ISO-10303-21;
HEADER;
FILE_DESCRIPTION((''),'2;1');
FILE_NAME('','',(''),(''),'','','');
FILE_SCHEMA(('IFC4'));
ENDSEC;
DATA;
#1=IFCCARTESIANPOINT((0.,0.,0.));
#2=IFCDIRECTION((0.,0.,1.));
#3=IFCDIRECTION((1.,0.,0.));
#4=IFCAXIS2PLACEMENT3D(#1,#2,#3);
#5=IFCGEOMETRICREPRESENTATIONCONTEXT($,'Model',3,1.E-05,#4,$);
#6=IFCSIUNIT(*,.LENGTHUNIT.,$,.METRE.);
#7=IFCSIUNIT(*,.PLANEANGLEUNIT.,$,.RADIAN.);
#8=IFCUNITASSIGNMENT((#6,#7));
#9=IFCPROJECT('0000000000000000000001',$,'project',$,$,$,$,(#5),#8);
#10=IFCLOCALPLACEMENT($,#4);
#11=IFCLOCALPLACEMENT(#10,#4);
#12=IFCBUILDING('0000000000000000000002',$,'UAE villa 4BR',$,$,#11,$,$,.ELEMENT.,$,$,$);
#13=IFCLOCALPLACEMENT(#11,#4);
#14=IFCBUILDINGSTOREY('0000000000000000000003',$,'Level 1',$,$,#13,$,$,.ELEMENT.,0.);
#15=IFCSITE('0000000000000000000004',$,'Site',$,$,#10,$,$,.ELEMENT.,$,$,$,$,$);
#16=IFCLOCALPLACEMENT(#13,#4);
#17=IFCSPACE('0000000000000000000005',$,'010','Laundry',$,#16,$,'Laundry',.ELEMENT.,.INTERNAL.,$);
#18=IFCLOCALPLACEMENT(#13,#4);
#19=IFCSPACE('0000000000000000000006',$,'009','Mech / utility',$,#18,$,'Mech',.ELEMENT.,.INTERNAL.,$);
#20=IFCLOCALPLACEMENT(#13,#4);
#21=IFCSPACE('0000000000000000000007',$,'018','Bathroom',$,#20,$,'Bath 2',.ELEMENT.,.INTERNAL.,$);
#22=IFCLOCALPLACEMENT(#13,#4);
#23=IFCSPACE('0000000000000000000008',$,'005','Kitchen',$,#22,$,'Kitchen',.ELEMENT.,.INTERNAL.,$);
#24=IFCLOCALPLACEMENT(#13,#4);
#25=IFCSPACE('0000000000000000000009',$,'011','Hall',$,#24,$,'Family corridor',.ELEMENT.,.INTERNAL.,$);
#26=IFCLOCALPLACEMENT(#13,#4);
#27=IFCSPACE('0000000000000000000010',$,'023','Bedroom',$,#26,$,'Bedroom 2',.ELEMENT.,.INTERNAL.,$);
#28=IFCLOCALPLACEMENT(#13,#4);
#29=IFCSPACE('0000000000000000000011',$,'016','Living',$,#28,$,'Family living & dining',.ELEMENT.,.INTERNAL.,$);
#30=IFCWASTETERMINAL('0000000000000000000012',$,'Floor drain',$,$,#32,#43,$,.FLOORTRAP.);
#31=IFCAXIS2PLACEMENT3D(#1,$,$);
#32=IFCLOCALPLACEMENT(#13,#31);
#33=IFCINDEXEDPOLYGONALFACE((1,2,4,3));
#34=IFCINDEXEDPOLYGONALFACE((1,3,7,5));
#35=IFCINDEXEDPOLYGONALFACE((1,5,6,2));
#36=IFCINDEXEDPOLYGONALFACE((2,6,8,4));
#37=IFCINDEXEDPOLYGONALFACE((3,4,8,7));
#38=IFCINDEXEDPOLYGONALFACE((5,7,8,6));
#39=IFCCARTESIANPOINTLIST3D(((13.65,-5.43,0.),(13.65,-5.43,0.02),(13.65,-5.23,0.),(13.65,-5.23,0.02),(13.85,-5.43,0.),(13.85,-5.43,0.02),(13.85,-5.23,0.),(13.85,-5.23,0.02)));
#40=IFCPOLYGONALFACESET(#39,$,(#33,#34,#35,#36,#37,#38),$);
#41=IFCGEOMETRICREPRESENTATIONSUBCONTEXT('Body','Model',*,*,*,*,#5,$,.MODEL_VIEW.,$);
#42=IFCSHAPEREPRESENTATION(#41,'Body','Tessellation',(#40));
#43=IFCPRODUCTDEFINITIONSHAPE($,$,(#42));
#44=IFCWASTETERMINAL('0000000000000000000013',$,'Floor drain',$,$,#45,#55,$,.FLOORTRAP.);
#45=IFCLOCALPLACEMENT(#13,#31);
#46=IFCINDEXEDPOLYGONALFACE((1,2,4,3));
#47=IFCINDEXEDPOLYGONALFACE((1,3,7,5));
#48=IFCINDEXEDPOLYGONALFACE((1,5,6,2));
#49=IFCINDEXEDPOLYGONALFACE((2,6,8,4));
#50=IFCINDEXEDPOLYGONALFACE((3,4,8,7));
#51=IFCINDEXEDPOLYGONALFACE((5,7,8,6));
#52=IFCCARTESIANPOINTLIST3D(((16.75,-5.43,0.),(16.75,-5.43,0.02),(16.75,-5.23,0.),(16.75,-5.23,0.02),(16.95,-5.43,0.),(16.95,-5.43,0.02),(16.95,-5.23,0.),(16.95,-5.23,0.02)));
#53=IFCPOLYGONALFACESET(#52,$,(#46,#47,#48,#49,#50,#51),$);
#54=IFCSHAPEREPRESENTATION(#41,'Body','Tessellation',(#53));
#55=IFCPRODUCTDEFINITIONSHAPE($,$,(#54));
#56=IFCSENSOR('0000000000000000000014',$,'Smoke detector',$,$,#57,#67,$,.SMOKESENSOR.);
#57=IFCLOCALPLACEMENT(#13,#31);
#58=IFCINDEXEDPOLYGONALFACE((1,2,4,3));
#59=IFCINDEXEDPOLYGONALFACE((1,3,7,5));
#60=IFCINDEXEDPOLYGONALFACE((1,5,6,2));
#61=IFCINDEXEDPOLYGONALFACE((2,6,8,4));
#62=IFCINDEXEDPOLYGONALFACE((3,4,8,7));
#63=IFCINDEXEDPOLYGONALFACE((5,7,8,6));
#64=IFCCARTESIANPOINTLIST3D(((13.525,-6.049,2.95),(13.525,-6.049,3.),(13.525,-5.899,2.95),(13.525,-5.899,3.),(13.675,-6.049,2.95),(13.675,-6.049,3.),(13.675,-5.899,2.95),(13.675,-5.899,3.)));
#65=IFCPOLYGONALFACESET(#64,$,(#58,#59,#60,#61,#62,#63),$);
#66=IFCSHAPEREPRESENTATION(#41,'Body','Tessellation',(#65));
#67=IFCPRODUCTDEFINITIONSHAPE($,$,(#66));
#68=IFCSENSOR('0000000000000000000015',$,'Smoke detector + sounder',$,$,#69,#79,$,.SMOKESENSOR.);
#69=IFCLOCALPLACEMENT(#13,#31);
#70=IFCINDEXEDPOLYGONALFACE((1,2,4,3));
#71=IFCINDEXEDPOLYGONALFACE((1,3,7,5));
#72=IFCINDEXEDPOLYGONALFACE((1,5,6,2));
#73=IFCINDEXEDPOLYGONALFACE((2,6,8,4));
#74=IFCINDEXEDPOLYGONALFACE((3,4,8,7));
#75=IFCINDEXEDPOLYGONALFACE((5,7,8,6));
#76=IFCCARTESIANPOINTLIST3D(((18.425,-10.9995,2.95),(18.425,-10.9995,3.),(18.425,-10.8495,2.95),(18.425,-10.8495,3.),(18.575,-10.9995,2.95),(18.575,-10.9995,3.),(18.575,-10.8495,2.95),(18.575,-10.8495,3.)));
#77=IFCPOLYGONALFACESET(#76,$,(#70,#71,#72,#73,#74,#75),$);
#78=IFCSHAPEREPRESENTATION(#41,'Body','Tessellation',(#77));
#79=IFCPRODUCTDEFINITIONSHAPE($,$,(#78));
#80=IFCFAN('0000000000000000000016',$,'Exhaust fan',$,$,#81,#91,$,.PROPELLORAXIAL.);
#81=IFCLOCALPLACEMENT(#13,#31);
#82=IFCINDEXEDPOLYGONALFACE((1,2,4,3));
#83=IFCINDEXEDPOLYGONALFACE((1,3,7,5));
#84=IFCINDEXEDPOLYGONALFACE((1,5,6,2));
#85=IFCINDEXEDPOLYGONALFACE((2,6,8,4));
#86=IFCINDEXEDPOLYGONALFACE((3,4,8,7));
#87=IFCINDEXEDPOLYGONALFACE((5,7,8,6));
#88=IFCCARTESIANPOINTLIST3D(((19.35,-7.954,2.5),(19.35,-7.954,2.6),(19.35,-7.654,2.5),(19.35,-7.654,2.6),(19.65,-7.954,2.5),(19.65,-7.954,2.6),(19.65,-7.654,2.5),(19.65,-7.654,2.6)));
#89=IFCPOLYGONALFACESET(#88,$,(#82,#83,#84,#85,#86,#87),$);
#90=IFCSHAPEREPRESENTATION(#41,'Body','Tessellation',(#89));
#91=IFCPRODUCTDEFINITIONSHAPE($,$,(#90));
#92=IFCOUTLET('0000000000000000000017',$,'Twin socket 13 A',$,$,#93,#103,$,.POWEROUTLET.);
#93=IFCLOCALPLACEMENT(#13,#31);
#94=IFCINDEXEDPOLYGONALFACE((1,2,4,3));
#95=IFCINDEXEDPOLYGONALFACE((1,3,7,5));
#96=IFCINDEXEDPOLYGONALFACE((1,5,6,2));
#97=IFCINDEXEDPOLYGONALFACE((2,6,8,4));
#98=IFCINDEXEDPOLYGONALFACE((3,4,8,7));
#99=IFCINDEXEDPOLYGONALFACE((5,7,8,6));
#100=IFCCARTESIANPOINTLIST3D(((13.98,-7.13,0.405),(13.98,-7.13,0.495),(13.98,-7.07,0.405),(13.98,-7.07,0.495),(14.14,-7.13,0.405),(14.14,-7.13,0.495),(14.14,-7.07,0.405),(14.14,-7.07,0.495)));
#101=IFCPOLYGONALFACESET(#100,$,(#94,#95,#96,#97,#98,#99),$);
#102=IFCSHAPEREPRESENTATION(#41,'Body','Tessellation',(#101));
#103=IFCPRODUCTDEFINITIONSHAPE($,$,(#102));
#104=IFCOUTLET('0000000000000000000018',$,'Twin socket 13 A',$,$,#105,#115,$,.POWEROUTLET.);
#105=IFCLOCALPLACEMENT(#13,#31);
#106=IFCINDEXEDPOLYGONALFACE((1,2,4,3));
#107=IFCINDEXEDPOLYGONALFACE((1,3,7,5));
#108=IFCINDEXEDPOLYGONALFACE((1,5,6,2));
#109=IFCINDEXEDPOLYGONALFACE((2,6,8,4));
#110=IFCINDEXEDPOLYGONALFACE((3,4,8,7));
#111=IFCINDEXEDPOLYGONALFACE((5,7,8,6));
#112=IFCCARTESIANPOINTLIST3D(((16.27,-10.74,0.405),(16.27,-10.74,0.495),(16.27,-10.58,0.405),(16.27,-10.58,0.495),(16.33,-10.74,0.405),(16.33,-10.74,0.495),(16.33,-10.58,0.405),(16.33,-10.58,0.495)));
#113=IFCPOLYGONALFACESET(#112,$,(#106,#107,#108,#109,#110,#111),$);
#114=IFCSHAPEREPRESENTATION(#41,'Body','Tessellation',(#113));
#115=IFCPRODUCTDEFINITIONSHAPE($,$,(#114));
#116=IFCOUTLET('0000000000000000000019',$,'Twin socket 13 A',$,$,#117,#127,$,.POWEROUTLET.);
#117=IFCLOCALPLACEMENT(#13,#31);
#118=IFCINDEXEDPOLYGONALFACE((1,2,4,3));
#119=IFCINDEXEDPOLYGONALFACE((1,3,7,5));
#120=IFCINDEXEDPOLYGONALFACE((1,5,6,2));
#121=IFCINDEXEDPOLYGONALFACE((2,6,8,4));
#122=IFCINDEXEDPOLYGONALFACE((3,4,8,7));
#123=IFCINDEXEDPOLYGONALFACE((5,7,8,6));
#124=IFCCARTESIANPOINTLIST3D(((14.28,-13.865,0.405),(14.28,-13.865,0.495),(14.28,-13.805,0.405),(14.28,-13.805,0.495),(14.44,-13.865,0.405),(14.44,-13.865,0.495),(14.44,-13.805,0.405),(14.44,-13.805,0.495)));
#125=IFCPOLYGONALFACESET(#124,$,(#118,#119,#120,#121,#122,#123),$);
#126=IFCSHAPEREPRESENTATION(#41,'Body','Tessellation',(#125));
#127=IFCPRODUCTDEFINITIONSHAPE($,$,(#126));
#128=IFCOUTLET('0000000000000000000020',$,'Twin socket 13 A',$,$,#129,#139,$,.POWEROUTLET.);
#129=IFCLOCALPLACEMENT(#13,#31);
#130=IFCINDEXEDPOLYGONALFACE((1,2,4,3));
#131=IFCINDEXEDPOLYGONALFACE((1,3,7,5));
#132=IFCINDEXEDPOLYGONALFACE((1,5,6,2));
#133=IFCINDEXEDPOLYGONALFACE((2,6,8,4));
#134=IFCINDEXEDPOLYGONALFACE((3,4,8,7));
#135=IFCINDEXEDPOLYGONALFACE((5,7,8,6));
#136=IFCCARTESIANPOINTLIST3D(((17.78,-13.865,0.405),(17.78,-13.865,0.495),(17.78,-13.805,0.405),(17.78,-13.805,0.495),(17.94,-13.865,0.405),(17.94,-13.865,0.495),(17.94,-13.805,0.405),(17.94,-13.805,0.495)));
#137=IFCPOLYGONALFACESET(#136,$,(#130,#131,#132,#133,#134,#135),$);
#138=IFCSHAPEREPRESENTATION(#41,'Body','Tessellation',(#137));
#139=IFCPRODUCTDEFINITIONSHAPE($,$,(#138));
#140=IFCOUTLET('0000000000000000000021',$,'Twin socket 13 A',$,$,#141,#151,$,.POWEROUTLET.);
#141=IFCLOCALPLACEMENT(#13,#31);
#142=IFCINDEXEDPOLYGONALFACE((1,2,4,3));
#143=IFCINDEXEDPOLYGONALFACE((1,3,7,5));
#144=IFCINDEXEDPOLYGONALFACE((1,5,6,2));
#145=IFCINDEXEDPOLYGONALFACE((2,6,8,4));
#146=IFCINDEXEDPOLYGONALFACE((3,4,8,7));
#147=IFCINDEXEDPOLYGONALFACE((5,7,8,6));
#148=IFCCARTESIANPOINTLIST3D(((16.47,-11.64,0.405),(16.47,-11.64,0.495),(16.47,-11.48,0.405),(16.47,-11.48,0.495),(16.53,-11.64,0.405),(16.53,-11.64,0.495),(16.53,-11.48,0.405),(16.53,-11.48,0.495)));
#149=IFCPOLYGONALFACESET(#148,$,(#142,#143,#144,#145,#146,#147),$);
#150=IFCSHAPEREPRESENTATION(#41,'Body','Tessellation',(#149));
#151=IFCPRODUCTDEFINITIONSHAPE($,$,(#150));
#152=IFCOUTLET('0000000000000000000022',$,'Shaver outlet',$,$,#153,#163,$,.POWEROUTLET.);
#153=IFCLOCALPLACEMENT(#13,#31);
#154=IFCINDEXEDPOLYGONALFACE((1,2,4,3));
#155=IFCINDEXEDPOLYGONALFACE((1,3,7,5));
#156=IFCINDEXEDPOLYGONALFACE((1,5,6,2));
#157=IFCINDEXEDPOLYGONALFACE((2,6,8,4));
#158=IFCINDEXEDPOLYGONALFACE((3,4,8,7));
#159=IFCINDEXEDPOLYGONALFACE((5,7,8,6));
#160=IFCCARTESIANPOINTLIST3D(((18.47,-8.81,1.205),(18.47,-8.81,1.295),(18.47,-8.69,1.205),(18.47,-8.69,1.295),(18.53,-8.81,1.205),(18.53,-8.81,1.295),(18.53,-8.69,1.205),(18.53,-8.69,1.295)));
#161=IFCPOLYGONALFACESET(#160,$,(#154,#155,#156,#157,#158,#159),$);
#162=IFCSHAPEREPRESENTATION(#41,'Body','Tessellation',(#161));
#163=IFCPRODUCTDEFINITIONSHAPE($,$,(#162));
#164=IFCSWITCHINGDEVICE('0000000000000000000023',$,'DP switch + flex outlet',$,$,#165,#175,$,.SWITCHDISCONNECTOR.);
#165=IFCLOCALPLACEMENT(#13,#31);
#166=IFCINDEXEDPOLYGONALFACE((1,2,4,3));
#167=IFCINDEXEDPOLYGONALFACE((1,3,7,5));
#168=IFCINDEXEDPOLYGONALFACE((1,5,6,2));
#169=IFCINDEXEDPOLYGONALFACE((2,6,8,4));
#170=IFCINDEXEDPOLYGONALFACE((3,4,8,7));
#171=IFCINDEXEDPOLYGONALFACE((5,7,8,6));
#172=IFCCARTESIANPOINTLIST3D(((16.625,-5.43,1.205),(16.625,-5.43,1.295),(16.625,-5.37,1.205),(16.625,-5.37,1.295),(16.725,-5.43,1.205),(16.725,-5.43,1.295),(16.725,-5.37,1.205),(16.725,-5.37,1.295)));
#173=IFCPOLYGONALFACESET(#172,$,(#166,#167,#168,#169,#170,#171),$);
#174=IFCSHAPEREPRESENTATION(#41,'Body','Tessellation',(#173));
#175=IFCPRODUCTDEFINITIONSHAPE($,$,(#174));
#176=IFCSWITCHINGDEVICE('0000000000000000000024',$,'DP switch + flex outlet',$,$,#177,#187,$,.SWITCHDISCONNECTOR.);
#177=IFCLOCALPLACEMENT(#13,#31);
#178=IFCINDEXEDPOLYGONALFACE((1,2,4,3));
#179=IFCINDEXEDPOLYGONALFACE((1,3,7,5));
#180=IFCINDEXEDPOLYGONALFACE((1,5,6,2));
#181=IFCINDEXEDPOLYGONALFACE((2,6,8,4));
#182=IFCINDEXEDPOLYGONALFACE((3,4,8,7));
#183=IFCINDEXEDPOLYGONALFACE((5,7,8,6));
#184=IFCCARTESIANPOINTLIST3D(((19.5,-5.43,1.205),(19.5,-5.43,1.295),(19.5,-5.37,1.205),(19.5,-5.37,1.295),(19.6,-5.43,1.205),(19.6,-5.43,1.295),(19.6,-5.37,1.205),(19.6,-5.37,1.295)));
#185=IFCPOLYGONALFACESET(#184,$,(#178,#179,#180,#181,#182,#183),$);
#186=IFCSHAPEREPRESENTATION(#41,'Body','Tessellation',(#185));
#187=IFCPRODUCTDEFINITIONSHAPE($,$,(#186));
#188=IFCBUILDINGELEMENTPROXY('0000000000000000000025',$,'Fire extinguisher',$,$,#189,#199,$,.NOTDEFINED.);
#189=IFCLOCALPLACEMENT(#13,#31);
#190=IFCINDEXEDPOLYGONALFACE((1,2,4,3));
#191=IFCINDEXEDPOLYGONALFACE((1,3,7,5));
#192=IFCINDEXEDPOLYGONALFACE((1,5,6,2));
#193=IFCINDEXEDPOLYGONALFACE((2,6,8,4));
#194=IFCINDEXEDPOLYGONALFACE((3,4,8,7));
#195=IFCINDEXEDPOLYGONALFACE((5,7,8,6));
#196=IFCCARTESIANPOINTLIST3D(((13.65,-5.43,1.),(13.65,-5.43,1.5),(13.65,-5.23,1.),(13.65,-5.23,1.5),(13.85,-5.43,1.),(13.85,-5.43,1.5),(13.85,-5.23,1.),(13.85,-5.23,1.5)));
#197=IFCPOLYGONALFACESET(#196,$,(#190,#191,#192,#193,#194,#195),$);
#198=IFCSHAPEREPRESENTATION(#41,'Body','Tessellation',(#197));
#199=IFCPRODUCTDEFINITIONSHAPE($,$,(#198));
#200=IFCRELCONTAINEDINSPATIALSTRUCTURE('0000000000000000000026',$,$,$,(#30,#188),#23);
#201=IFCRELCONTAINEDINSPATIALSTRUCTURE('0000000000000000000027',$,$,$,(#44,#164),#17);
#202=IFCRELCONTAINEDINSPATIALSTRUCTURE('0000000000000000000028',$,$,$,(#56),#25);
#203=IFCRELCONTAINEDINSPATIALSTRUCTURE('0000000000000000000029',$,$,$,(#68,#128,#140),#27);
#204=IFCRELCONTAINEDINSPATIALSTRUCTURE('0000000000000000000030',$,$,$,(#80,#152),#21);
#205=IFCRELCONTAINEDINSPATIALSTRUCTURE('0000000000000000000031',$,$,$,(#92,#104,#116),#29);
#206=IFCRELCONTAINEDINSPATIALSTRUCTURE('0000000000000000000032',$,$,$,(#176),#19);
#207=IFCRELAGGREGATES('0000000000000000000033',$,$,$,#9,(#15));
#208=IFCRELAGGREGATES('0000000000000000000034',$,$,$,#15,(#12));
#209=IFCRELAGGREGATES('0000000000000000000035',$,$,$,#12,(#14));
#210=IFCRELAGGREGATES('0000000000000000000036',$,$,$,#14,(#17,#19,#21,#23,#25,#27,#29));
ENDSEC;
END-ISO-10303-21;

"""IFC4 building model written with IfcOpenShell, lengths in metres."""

from ifc_helpers import new_model, si_unit, frame, origin, origin_with_axes, origin_2d, place, context, subcontext, project, spatial, rectangle, extrude, element, save


model = new_model("IFC4")

# Units and contexts
model_context = context("Model", 3, precision=1e-05, world=origin_with_axes())
body_context = subcontext(model_context, "Body", "Model", "MODEL_VIEW")
ifc_project = project(units=[si_unit("LENGTHUNIT", "METRE"), si_unit("PLANEANGLEUNIT", "RADIAN")], contexts=[model_context])

# Site, building, storey
site_placement = place(None, origin_with_axes())
site = spatial("IfcSite", under=ifc_project, at=site_placement, Name="Site", CompositionType="ELEMENT")
building_placement = place(site_placement, origin_with_axes())
building = spatial("IfcBuilding", under=site, at=building_placement, Name="UAE villa 4BR", CompositionType="ELEMENT")
storey_placement = place(building_placement, origin_with_axes())
storey = spatial("IfcBuildingStorey", under=building, at=storey_placement, Name="Level 1", CompositionType="ELEMENT", Elevation=0.0)

# Shared definitions
space_1_placement = place(storey_placement, origin_with_axes())
space_1 = spatial("IfcSpace", under=storey, at=space_1_placement, Name="010", Description="Laundry", LongName="Laundry", CompositionType="ELEMENT", PredefinedType="INTERNAL")

# Shared definitions
space_2_placement = place(storey_placement, origin_with_axes())
space_2 = spatial("IfcSpace", under=storey, at=space_2_placement, Name="009", Description="Mech / utility", LongName="Mech", CompositionType="ELEMENT", PredefinedType="INTERNAL")

# Shared definitions
space_3_placement = place(storey_placement, origin_with_axes())
space_3 = spatial("IfcSpace", under=storey, at=space_3_placement, Name="018", Description="Bathroom", LongName="Bath 2", CompositionType="ELEMENT", PredefinedType="INTERNAL")

# Shared definitions
space_4_placement = place(storey_placement, origin_with_axes())
space_4 = spatial("IfcSpace", under=storey, at=space_4_placement, Name="005", Description="Kitchen", LongName="Kitchen", CompositionType="ELEMENT", PredefinedType="INTERNAL")

# Waste terminals
waste_terminal_1_placement = place(storey_placement, frame((13.75, -5.33, 0.0), z_axis=(0.0, 0.0, 1.0), x_axis=(-1.0, 0.0, 0.0)))
element("IfcWasteTerminal", 1, at=waste_terminal_1_placement, inside=space_4, Name="Floor drain", PredefinedType="FLOORTRAP", context=body_context, shape_type="SweptSolid", body=[
    extrude(rectangle(XDim=0.2, YDim=0.2, at=origin_2d()), origin(), (0.0, 0.0, 1.0), 0.02),
])
waste_terminal_2_placement = place(storey_placement, frame((16.85, -5.33, 0.0), z_axis=(0.0, 0.0, 1.0), x_axis=(-1.0, 0.0, 0.0)))
element("IfcWasteTerminal", 2, at=waste_terminal_2_placement, inside=space_1, Name="Floor drain", PredefinedType="FLOORTRAP", context=body_context, shape_type="SweptSolid", body=[
    extrude(rectangle(XDim=0.2, YDim=0.2, at=origin_2d()), origin(), (0.0, 0.0, 1.0), 0.02),
])

# Shared definitions
space_5_placement = place(storey_placement, origin_with_axes())
space_5 = spatial("IfcSpace", under=storey, at=space_5_placement, Name="011", Description="Hall", LongName="Family corridor", CompositionType="ELEMENT", PredefinedType="INTERNAL")

# Sensor
sensor_1_placement = place(storey_placement, frame((13.6, -5.974, 2.95), z_axis=(0.0, 0.0, 1.0), x_axis=(1.0, 0.0, 0.0)))
element("IfcSensor", 3, at=sensor_1_placement, inside=space_5, Name="Smoke detector", PredefinedType="SMOKESENSOR", context=body_context, shape_type="SweptSolid", body=[
    extrude(rectangle(XDim=0.15, YDim=0.15, at=origin_2d()), origin(), (0.0, 0.0, 1.0), 0.05),
])

# Shared definitions
space_6_placement = place(storey_placement, origin_with_axes())
space_6 = spatial("IfcSpace", under=storey, at=space_6_placement, Name="023", Description="Bedroom", LongName="Bedroom 2", CompositionType="ELEMENT", PredefinedType="INTERNAL")

# Sensor
sensor_2_placement = place(storey_placement, frame((18.5, -10.9245, 2.95), z_axis=(0.0, 0.0, 1.0), x_axis=(1.0, 0.0, 0.0)))
element("IfcSensor", 4, at=sensor_2_placement, inside=space_6, Name="Smoke detector + sounder", PredefinedType="SMOKESENSOR", context=body_context, shape_type="SweptSolid", body=[
    extrude(rectangle(XDim=0.15, YDim=0.15, at=origin_2d()), origin(), (0.0, 0.0, 1.0), 0.05),
])

# Fan
fan_placement = place(storey_placement, frame((19.5, -7.804, 2.5), z_axis=(0.0, 0.0, 1.0), x_axis=(1.0, 0.0, 0.0)))
element("IfcFan", 5, at=fan_placement, inside=space_3, Name="Exhaust fan", PredefinedType="PROPELLORAXIAL", context=body_context, shape_type="SweptSolid", body=[
    extrude(rectangle(XDim=0.3, YDim=0.3, at=origin_2d()), origin(), (0.0, 0.0, 1.0), 0.1),
])

# Shared definitions
space_7_placement = place(storey_placement, origin_with_axes())
space_7 = spatial("IfcSpace", under=storey, at=space_7_placement, Name="016", Description="Living", LongName="Family living & dining", CompositionType="ELEMENT", PredefinedType="INTERNAL")

# Outlets
for number, where, z_axis, x_axis, name in (
    (6, (14.06, -7.1, 0.405), (0.0, 0.0, 1.0), (1.0, 0.0, 0.0), "Twin socket 13 A"),
    (7, (16.3, -10.66, 0.405), (0.0, 0.0, 1.0), (0.0, -1.0, 0.0), "Twin socket 13 A"),
    (8, (14.36, -13.835, 0.405), (0.0, 0.0, 1.0), (-1.0, 0.0, 0.0), "Twin socket 13 A"),
):
    element("IfcOutlet", number, at=place(storey_placement, frame(where, z_axis=z_axis, x_axis=x_axis)), inside=space_7, Name=name, PredefinedType="POWEROUTLET", context=body_context, shape_type="SweptSolid", body=[
        extrude(rectangle(XDim=0.16, YDim=0.06, at=origin_2d()), origin(), (0.0, 0.0, 1.0), 0.09),
    ])
for number, where, z_axis, x_axis, name in (
    (9, (17.86, -13.835, 0.405), (0.0, 0.0, 1.0), (-1.0, 0.0, 0.0), "Twin socket 13 A"),
    (10, (16.5, -11.56, 0.405), (0.0, 0.0, 1.0), (0.0, 1.0, 0.0), "Twin socket 13 A"),
):
    element("IfcOutlet", number, at=place(storey_placement, frame(where, z_axis=z_axis, x_axis=x_axis)), inside=space_6, Name=name, PredefinedType="POWEROUTLET", context=body_context, shape_type="SweptSolid", body=[
        extrude(rectangle(XDim=0.16, YDim=0.06, at=origin_2d()), origin(), (0.0, 0.0, 1.0), 0.09),
    ])
outlet_placement = place(storey_placement, frame((18.5, -8.75, 1.205), z_axis=(0.0, 0.0, 1.0), x_axis=(0.0, 1.0, 0.0)))
element("IfcOutlet", 11, at=outlet_placement, inside=space_3, Name="Shaver outlet", PredefinedType="POWEROUTLET", context=body_context, shape_type="SweptSolid", body=[
    extrude(rectangle(XDim=0.12, YDim=0.06, at=origin_2d()), origin(), (0.0, 0.0, 1.0), 0.09),
])

# Switching devices
switching_device_1_placement = place(storey_placement, frame((16.675, -5.4, 1.205), z_axis=(0.0, 0.0, 1.0), x_axis=(-1.0, 0.0, 0.0)))
element("IfcSwitchingDevice", 12, at=switching_device_1_placement, inside=space_1, Name="DP switch + flex outlet", PredefinedType="SWITCHDISCONNECTOR", context=body_context, shape_type="SweptSolid", body=[
    extrude(rectangle(XDim=0.1, YDim=0.06, at=origin_2d()), origin(), (0.0, 0.0, 1.0), 0.09),
])
switching_device_2_placement = place(storey_placement, frame((19.55, -5.4, 1.205), z_axis=(0.0, 0.0, 1.0), x_axis=(-1.0, 0.0, 0.0)))
element("IfcSwitchingDevice", 13, at=switching_device_2_placement, inside=space_2, Name="DP switch + flex outlet", PredefinedType="SWITCHDISCONNECTOR", context=body_context, shape_type="SweptSolid", body=[
    extrude(rectangle(XDim=0.1, YDim=0.06, at=origin_2d()), origin(), (0.0, 0.0, 1.0), 0.09),
])

# Building element proxy
proxy_placement = place(storey_placement, frame((13.75, -5.33, 1.0), z_axis=(0.0, 0.0, 1.0), x_axis=(-1.0, 0.0, 0.0)))
element("IfcBuildingElementProxy", 14, at=proxy_placement, inside=space_4, Name="Fire extinguisher", PredefinedType="NOTDEFINED", context=body_context, shape_type="SweptSolid", body=[
    extrude(rectangle(XDim=0.2, YDim=0.2, at=origin_2d()), origin(), (0.0, 0.0, 1.0), 0.5),
])

save(model, "model.ifc")
